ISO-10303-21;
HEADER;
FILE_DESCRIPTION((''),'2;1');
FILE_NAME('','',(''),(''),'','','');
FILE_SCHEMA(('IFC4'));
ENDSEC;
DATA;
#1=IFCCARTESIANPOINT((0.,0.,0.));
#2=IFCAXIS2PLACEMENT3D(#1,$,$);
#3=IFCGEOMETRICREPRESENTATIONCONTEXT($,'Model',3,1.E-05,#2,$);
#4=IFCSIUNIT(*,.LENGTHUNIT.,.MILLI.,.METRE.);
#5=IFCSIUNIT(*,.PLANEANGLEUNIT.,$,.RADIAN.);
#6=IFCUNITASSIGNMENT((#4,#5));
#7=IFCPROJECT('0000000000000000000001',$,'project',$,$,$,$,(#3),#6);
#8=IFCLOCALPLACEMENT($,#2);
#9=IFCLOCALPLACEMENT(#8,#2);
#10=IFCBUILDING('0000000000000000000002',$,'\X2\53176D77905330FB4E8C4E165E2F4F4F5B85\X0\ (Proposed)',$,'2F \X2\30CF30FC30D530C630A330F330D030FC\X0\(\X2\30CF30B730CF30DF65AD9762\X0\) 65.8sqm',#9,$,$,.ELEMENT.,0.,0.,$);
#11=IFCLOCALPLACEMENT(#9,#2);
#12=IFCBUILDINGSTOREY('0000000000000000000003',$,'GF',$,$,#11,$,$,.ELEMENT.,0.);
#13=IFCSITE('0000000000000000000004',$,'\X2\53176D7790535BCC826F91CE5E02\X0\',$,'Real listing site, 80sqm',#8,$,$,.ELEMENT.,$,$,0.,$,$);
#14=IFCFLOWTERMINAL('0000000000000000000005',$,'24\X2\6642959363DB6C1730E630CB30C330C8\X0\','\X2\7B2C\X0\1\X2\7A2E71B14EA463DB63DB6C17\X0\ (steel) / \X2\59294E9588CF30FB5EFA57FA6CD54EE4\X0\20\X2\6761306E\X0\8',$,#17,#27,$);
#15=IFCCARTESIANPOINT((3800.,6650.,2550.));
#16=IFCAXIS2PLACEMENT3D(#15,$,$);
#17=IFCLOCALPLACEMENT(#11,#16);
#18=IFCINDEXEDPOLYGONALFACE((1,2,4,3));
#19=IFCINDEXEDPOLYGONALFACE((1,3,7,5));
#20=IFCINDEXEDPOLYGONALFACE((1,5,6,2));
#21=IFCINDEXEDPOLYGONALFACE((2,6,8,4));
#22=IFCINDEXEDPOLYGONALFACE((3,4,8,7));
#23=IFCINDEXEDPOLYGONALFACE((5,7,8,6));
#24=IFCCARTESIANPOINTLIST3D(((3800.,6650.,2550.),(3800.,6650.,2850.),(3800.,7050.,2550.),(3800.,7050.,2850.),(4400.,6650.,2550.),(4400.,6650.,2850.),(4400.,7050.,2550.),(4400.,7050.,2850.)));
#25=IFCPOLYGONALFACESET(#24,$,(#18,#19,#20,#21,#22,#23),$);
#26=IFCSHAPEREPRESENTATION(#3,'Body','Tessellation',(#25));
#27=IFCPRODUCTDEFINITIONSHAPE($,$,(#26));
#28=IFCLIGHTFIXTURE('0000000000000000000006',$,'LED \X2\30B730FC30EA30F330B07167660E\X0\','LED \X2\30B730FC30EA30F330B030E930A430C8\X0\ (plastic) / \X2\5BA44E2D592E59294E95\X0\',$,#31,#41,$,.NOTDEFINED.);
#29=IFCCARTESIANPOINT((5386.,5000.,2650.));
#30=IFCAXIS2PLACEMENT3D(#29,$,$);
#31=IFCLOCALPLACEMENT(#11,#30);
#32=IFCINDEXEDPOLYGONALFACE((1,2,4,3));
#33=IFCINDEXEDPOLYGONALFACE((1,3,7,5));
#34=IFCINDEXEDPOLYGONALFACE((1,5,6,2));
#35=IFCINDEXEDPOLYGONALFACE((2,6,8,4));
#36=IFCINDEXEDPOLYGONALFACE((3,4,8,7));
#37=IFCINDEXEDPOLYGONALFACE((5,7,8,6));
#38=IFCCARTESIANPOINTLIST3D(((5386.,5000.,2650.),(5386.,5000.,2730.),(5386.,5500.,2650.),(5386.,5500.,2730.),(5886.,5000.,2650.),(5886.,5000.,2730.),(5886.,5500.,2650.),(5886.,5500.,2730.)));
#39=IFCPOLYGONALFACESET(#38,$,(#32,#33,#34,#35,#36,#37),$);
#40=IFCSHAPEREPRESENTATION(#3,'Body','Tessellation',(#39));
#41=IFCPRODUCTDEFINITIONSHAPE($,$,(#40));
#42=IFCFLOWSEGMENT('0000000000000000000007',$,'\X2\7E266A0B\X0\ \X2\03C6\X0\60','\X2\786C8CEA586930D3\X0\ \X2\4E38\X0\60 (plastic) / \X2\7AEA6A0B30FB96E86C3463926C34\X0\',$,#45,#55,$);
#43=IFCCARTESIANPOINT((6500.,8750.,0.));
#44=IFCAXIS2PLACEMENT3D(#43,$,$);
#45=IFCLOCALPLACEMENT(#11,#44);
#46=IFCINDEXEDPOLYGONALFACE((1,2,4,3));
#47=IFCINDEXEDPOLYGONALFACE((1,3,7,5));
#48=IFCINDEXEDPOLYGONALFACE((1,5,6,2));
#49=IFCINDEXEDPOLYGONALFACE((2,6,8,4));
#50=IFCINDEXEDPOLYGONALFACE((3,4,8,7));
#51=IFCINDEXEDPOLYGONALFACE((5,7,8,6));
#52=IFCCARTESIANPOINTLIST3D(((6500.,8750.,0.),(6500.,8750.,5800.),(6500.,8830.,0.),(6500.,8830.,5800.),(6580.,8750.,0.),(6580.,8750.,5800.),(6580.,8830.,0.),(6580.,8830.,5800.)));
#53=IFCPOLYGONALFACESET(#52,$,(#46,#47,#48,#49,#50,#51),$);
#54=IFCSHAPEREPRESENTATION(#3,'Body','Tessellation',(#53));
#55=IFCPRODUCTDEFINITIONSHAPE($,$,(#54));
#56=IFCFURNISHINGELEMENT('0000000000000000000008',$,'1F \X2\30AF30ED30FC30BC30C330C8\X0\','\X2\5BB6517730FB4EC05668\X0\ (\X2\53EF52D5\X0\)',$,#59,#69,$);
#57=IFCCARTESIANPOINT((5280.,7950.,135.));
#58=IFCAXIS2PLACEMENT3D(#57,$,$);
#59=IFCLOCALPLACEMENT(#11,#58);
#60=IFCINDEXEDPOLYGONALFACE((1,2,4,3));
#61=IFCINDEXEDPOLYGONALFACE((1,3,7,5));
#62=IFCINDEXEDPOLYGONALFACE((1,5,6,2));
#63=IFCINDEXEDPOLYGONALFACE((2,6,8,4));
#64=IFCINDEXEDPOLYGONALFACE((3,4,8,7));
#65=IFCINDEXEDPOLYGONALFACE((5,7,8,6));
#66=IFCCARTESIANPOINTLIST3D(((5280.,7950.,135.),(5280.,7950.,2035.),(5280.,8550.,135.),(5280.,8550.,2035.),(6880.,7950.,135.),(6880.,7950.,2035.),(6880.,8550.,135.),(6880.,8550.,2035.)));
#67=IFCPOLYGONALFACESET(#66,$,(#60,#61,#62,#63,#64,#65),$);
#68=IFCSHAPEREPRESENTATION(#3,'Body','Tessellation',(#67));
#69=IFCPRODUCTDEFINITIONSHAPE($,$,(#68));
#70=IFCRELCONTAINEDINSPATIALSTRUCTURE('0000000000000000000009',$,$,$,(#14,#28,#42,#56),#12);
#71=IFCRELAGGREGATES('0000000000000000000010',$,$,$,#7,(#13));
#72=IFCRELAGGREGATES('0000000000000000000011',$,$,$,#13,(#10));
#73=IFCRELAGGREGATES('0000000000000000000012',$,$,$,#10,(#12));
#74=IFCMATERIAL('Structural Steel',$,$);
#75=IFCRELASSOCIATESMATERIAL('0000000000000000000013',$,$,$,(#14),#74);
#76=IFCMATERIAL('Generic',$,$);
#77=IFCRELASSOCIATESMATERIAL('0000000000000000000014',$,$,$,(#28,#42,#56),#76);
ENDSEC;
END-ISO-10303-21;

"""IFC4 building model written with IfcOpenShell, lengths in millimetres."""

from ifc_helpers import new_model, si_unit, frame, frame_2d, origin, place, context, project, spatial, rectangle, extrude, material, element, save


model = new_model("IFC4")

# Units and contexts
model_context = context("Model", 3, precision=1e-05, world=origin())
ifc_project = project(units=[si_unit("LENGTHUNIT", "METRE", prefix="MILLI"), si_unit("PLANEANGLEUNIT", "RADIAN")], contexts=[model_context])

# Site, building, storey
site_placement = place(None, origin())
site = spatial("IfcSite", under=ifc_project, at=site_placement, Name="北海道富良野市", ObjectType="Real listing site, 80sqm", CompositionType="ELEMENT", RefElevation=0.0)
building_placement = place(site_placement, origin())
building = spatial("IfcBuilding", under=site, at=building_placement, Name="北海道・二世帯住宅 (Proposed)", ObjectType="2F ハーフティンバー(ハシハミ断面) 65.8sqm", CompositionType="ELEMENT", ElevationOfRefHeight=0.0, ElevationOfTerrain=0.0)
storey_placement = place(building_placement, origin())
storey = spatial("IfcBuildingStorey", under=building, at=storey_placement, Name="GF", CompositionType="ELEMENT", Elevation=0.0)

# Shared definitions
ifc_material_1 = material(Name="Generic")

# Flow terminal
ifc_material_2 = material(Name="Structural Steel")
flow_terminal_placement = place(storey_placement, frame((3800.0, 6650.0, 2550.0)))
element("IfcFlowTerminal", 1, at=flow_terminal_placement, inside=storey, material=ifc_material_2, Name="24時間換気ユニット", Description="第1種熱交換換気 (steel) / 天井裏・建基法令20条の8", context=model_context, shape_type="SweptSolid", body=[
    extrude(rectangle(XDim=600.0, YDim=400.0, at=frame_2d((300.0, 200.0))), frame((3800.0, 6650.0, 2550.0)), (0.0, 0.0, 1.0), 300.0),
])

# Light fixture
light_fixture_placement = place(storey_placement, frame((5386.0, 5000.0, 2650.0)))
element("IfcLightFixture", 2, at=light_fixture_placement, inside=storey, material=ifc_material_1, Name="LED シーリング照明", Description="LED シーリングライト (plastic) / 室中央天井", PredefinedType="NOTDEFINED", context=model_context, shape_type="SweptSolid", body=[
    extrude(rectangle(XDim=500.0, YDim=500.0, at=frame_2d((250.0, 250.0))), frame((5386.0, 5000.0, 2650.0)), (0.0, 0.0, 1.0), 80.0),
])

# Flow segment
flow_segment_placement = place(storey_placement, frame((6500.0, 8750.0, 0.0)))
element("IfcFlowSegment", 3, at=flow_segment_placement, inside=storey, material=ifc_material_1, Name="縦樋 φ60", Description="硬質塩ビ 丸60 (plastic) / 竪樋・雨水排水", context=model_context, shape_type="SweptSolid", body=[
    extrude(rectangle(XDim=80.0, YDim=80.0, at=frame_2d((40.0, 40.0))), frame((6500.0, 8750.0, 0.0)), (0.0, 0.0, 1.0), 5800.0),
])

# Furnishing element
furnishing_placement = place(storey_placement, frame((5280.0, 7950.0, 135.0)))
element("IfcFurnishingElement", 4, at=furnishing_placement, inside=storey, material=ifc_material_1, Name="1F クローゼット", Description="家具・什器 (可動)", context=model_context, shape_type="SweptSolid", body=[
    extrude(rectangle(XDim=1600.0, YDim=600.0, at=frame_2d((800.0, 300.0))), frame((5280.0, 7950.0, 135.0)), (0.0, 0.0, 1.0), 1900.0),
])

save(model, "model.ifc")
